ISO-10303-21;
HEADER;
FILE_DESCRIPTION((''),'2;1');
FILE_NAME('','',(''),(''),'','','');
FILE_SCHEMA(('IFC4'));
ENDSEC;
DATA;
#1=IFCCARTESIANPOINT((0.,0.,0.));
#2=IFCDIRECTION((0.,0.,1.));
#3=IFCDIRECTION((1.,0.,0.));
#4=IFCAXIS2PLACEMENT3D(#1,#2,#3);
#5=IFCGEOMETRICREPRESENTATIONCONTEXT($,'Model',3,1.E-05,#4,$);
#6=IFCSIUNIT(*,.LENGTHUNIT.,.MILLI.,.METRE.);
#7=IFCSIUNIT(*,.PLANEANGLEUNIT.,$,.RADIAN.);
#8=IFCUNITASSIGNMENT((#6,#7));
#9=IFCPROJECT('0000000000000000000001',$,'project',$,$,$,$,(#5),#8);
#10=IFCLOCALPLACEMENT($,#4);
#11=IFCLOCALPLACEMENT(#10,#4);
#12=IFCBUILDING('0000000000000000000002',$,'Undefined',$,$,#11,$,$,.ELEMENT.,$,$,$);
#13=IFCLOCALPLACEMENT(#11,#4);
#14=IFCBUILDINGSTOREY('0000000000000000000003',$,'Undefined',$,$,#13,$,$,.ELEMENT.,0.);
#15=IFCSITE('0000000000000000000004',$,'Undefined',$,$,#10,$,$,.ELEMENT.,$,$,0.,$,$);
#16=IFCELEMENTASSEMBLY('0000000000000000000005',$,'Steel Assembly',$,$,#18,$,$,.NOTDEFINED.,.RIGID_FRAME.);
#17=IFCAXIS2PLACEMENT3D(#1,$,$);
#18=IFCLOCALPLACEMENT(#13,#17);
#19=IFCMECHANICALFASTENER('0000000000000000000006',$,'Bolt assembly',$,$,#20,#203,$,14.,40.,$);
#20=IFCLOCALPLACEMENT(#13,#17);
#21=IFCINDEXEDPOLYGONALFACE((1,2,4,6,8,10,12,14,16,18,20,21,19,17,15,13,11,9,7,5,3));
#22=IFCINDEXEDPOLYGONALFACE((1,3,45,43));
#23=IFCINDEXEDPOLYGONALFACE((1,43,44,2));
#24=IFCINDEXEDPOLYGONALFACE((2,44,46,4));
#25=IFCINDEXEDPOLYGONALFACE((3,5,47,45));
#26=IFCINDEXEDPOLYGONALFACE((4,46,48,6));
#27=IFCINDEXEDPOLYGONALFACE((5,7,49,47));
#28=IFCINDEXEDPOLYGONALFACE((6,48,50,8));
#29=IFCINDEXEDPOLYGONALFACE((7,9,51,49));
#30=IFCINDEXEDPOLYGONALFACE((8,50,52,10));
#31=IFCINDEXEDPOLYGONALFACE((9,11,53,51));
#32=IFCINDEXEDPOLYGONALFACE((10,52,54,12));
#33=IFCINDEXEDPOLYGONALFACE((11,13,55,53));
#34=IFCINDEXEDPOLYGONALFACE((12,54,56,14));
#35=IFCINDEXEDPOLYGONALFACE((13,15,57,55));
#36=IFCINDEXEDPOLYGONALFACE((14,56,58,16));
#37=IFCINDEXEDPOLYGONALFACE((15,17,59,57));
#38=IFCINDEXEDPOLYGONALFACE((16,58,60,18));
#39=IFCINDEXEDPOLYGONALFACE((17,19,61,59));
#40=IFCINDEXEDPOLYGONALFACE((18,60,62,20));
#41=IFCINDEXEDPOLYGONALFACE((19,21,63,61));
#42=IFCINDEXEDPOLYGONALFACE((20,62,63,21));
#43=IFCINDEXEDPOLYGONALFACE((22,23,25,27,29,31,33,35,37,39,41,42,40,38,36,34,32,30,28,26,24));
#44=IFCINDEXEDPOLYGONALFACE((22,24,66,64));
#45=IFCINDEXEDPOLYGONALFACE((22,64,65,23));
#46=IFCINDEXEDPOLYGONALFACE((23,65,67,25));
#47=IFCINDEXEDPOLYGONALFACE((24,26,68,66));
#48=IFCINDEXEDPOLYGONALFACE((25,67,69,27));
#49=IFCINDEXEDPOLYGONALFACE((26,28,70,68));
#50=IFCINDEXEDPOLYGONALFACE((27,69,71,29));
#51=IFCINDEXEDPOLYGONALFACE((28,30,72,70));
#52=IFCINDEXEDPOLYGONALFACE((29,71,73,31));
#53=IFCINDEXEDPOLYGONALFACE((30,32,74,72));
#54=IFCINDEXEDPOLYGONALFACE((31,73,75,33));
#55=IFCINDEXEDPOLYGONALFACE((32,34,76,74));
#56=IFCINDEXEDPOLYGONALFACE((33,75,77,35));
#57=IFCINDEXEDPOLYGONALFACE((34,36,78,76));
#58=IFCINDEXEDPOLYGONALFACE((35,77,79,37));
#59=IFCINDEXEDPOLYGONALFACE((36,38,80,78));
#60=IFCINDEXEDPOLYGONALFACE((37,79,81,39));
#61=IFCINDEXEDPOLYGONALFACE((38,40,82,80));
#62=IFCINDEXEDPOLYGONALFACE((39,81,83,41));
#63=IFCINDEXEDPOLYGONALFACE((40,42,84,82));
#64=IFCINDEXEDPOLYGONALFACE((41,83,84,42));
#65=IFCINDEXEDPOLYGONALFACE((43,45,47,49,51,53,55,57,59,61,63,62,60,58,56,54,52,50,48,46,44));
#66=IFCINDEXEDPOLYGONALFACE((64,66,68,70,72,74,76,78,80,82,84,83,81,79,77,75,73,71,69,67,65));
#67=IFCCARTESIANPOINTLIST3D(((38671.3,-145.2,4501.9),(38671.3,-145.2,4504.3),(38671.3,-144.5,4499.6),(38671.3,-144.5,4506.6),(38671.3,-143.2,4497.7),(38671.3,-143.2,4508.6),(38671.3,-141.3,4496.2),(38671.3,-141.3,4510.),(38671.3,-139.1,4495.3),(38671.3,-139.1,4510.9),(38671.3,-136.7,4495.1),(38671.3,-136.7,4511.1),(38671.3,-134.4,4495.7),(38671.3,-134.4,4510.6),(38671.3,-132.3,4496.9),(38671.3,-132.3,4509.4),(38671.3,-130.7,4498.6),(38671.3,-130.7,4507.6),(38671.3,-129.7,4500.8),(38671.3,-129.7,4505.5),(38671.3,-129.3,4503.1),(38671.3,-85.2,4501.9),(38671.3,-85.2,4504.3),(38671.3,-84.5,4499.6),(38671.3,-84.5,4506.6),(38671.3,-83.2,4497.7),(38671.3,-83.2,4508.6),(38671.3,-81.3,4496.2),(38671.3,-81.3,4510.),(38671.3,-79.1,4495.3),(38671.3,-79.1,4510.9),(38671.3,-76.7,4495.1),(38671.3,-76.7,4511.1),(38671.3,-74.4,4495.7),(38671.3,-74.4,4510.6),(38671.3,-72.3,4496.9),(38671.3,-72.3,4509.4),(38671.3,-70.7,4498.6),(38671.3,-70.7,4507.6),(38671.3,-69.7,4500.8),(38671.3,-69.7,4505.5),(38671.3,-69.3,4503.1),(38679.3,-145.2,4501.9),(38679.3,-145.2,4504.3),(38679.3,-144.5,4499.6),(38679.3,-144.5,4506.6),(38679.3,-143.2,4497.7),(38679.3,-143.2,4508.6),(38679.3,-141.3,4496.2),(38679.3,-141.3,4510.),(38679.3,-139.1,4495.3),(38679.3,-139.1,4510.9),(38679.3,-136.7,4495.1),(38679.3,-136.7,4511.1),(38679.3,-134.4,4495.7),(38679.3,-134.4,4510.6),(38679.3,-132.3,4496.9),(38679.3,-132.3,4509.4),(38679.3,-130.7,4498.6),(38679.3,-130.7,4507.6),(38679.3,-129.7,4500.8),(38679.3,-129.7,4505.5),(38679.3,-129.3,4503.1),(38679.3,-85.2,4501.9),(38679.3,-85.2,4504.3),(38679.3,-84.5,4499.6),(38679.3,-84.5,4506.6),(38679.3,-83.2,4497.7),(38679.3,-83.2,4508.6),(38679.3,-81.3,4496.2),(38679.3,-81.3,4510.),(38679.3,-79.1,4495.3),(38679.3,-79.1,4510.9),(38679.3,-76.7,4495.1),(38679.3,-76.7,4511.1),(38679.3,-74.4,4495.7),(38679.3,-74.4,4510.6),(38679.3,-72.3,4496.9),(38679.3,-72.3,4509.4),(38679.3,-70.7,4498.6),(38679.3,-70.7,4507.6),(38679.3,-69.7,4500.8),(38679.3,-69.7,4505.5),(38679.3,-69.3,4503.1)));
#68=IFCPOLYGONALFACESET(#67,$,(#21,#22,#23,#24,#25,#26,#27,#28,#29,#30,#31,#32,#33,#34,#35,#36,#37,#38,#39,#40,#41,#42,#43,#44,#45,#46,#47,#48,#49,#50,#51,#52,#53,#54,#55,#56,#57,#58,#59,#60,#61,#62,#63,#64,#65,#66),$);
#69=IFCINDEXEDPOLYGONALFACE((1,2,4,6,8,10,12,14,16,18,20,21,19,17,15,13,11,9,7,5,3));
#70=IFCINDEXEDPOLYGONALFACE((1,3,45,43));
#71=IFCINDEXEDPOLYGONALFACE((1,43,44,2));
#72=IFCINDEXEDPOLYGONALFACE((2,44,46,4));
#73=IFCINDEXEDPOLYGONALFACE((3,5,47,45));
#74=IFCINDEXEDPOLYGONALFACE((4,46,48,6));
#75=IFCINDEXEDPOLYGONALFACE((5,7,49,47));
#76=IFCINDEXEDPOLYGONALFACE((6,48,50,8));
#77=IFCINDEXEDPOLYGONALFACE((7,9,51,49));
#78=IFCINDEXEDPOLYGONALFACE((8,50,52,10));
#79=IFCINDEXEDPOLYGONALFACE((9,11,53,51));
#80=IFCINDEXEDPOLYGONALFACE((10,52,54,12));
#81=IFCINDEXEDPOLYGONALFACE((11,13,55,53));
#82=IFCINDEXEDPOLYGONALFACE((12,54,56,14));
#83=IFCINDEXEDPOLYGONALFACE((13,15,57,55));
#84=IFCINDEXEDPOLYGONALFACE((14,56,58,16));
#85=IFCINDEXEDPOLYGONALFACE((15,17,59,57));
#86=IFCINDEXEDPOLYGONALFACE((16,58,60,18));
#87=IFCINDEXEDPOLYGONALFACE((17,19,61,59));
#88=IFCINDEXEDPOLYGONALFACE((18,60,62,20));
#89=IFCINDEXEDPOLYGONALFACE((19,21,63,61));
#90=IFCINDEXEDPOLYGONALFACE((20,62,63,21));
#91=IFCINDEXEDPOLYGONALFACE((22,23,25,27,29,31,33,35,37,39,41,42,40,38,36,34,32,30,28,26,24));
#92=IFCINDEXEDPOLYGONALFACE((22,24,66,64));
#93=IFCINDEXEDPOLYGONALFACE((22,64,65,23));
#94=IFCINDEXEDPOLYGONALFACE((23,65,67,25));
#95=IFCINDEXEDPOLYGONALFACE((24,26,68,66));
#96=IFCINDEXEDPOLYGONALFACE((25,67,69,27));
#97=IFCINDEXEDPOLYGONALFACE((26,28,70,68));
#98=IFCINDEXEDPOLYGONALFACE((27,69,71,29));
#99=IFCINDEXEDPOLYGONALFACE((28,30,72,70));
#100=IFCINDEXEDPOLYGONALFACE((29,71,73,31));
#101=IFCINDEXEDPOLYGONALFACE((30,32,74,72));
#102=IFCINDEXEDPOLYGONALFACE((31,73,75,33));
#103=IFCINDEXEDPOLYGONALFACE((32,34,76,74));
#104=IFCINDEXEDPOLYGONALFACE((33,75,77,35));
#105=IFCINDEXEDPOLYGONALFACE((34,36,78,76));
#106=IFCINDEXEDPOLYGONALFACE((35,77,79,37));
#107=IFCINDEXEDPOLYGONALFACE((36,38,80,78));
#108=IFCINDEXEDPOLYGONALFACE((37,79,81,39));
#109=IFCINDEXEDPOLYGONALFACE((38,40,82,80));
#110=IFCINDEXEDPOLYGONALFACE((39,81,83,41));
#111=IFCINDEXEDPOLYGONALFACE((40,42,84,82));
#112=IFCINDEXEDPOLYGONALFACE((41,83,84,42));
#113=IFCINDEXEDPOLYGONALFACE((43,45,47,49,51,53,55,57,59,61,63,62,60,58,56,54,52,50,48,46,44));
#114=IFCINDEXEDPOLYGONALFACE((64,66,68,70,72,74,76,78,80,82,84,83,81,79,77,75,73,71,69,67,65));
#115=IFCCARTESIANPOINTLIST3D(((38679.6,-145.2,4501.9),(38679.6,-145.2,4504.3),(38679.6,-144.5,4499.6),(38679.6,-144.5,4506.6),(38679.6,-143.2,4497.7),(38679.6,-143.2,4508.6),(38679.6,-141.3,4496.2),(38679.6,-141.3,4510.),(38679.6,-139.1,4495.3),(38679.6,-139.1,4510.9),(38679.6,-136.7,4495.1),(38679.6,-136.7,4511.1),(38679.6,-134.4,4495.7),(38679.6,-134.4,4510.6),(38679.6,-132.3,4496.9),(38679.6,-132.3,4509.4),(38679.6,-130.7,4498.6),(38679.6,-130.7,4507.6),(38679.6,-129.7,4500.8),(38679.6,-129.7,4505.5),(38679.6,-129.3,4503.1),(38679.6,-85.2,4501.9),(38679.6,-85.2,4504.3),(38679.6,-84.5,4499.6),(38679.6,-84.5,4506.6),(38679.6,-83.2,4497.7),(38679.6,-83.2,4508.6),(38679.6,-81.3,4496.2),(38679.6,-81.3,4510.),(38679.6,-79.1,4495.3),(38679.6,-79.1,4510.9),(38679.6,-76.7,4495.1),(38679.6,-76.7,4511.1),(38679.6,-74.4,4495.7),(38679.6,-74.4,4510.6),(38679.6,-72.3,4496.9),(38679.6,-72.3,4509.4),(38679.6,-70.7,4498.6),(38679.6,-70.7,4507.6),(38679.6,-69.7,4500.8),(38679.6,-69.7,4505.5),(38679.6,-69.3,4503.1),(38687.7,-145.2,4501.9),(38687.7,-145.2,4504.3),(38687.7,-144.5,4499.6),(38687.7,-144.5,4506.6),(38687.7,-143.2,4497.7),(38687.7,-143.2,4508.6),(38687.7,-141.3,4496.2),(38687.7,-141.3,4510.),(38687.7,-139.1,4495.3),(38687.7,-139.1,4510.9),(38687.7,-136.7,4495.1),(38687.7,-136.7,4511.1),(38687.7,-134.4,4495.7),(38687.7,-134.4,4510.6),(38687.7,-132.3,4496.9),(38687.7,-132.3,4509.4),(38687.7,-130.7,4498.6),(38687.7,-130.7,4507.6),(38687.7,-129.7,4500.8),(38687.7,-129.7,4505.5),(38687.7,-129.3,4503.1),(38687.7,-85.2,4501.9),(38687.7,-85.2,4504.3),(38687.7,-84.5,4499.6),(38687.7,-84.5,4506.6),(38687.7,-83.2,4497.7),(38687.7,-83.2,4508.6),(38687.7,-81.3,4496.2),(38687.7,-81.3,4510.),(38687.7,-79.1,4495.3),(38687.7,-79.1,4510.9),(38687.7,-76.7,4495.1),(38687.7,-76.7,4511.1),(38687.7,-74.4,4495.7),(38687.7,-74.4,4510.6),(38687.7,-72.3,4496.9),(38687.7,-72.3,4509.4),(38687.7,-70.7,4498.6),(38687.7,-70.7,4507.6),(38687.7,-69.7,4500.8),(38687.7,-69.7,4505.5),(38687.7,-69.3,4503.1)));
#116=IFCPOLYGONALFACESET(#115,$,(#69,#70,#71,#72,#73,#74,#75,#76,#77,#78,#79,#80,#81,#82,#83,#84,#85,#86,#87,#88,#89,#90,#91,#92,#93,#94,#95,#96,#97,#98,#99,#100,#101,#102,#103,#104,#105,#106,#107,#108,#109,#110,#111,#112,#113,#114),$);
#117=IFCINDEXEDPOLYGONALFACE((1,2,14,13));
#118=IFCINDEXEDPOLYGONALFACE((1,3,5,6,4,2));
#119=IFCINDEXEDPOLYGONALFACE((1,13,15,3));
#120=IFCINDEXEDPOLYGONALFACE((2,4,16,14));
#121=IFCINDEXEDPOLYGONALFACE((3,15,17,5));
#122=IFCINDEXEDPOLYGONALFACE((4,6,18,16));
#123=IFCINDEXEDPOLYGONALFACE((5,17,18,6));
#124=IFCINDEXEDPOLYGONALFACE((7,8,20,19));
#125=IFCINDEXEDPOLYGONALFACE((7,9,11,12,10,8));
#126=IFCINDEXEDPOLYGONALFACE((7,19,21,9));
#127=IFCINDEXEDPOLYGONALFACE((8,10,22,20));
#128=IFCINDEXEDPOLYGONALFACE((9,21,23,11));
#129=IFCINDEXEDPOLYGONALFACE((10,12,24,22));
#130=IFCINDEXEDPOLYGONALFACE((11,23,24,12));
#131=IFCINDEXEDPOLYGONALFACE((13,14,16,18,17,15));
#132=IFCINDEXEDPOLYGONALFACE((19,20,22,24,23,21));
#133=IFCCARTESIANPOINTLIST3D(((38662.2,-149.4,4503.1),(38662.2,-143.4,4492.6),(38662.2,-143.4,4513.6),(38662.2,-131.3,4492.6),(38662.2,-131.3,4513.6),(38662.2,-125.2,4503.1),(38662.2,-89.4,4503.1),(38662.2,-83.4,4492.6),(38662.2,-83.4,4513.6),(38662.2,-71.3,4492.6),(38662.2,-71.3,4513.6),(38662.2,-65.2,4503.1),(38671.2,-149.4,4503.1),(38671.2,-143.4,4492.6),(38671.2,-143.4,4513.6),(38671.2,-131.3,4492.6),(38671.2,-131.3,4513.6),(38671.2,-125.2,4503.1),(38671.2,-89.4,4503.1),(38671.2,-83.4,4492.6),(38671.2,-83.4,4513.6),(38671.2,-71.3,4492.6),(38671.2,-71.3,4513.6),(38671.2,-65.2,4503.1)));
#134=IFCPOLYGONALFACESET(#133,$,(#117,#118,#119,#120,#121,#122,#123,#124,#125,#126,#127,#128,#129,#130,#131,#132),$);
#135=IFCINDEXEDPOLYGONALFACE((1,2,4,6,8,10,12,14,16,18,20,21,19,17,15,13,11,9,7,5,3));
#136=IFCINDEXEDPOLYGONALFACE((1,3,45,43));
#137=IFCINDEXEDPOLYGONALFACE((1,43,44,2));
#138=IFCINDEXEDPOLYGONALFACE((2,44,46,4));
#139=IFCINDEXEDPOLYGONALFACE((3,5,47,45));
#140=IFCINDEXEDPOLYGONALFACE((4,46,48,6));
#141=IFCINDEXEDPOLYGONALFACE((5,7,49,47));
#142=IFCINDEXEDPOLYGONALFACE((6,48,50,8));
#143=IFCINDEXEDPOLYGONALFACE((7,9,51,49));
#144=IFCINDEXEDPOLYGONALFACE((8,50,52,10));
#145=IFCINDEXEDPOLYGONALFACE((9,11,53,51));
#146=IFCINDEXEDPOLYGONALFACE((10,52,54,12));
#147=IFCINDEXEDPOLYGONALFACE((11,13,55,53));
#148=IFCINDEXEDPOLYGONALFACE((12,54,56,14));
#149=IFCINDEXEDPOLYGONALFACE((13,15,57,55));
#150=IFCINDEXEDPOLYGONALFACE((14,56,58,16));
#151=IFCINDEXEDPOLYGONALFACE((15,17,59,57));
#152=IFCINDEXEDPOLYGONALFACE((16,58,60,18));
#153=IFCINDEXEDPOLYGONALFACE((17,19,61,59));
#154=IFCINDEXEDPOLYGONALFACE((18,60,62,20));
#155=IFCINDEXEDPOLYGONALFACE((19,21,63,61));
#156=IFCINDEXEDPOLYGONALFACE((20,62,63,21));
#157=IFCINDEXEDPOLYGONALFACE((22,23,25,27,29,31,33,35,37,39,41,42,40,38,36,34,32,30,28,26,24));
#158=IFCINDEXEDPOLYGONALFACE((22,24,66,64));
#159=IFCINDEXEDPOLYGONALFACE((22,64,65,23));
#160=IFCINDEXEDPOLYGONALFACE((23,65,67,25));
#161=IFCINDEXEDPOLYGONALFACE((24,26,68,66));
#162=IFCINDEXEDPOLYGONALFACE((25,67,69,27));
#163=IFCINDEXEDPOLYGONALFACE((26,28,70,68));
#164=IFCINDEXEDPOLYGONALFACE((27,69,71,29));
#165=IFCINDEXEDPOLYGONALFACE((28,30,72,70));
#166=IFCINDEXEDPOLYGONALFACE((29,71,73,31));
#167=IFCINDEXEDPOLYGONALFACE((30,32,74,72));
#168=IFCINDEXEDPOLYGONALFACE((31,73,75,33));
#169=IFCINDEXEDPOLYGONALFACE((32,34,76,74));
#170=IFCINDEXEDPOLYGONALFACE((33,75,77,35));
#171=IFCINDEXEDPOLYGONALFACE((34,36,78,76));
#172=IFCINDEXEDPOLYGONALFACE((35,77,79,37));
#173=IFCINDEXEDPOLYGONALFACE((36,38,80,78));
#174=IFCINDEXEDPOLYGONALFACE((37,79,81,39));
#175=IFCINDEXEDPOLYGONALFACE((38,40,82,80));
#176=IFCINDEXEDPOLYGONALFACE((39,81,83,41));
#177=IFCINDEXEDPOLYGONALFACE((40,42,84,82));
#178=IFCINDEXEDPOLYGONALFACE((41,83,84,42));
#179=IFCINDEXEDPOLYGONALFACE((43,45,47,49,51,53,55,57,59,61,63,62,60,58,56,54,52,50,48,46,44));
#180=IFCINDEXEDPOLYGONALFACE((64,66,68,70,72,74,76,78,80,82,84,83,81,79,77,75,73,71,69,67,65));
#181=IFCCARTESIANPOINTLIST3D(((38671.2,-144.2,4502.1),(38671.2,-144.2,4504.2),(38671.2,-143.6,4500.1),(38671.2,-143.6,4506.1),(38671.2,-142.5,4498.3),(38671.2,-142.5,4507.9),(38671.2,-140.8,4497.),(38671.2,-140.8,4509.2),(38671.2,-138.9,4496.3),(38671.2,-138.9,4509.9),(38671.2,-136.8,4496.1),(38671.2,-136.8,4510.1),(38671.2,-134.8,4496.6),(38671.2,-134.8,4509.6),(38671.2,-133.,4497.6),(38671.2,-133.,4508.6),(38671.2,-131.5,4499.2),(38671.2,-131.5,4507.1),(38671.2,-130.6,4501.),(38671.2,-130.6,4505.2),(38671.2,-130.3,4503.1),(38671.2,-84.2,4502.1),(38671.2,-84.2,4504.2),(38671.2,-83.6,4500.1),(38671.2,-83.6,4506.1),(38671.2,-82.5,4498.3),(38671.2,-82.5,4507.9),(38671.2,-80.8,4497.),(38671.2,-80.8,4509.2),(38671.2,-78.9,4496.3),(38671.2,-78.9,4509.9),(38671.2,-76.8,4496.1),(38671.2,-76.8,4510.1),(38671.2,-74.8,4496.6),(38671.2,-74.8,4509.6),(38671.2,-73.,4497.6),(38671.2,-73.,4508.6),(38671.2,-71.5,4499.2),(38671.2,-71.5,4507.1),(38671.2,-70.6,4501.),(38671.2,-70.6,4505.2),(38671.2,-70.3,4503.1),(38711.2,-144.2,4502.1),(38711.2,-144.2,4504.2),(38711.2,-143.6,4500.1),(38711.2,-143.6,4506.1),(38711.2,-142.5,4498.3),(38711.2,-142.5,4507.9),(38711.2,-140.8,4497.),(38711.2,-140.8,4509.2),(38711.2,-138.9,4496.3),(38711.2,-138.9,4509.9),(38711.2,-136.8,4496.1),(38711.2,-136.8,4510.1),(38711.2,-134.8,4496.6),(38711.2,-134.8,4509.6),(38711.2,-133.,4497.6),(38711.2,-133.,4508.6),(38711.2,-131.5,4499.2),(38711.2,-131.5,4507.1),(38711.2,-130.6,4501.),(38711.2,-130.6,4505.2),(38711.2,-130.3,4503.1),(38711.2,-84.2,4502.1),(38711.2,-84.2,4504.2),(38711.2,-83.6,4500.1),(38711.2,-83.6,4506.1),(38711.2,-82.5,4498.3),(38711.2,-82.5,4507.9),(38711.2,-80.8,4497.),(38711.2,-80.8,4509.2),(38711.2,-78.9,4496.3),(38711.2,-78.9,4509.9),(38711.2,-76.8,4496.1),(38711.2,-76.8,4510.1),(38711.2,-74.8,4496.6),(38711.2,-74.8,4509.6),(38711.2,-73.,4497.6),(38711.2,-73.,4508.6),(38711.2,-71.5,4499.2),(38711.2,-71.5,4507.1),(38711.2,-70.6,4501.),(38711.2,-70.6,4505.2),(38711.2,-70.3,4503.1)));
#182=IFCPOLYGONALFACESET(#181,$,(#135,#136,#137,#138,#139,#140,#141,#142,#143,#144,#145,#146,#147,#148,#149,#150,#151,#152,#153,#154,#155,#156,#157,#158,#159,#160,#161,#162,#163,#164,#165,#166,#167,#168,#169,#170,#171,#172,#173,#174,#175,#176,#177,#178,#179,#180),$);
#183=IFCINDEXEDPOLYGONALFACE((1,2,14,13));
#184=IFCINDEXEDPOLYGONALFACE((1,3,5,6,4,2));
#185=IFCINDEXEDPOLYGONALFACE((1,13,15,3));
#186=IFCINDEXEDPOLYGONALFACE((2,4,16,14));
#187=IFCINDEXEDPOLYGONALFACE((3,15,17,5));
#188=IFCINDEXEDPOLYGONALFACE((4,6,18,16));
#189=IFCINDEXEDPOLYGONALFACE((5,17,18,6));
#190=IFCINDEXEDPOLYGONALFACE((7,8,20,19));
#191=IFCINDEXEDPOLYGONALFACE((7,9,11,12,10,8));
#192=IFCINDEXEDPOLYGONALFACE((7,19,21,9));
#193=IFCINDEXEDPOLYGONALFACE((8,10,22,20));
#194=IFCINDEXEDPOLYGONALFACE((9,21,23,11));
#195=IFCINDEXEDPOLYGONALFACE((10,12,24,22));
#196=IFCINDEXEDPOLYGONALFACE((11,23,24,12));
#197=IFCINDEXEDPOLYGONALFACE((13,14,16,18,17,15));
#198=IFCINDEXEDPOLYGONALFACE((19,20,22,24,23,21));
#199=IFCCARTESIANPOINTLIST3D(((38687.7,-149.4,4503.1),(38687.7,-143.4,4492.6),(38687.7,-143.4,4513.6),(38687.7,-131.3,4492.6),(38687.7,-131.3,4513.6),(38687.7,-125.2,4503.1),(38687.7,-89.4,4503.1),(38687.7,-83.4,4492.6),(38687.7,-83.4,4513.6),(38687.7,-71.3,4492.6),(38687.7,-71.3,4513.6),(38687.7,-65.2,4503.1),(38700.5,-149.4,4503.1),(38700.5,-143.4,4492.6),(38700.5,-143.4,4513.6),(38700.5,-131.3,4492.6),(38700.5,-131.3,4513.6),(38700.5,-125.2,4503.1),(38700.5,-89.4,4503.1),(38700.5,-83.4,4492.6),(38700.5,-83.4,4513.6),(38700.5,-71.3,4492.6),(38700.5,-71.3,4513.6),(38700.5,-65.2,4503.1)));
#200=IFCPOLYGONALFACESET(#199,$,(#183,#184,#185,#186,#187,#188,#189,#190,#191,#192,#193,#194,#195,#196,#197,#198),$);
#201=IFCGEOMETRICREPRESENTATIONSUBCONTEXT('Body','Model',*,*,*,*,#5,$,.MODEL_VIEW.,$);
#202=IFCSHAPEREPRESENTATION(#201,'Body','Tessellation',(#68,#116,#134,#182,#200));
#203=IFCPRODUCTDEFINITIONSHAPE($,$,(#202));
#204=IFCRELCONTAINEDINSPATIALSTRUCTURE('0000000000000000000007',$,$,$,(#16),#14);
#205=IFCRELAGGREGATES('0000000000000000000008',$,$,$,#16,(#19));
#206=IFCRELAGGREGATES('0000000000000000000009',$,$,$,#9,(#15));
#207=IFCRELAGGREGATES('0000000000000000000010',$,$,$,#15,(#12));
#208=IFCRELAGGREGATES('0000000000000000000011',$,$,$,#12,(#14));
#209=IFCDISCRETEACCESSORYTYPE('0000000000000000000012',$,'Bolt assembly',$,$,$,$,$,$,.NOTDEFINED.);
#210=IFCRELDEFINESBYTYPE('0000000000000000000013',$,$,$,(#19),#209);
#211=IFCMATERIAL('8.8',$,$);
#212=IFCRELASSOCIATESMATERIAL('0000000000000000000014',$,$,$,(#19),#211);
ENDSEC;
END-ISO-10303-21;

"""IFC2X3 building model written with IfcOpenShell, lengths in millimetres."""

from ifc_helpers import new_model, si_unit, frame, origin_with_axes, origin_2d_with_axis, place, context, subcontext, project, spatial, polyline, circle, outline, extrude, source, transform, mapped, material, type_object, element, aggregate, save


model = new_model("IFC2X3")

# Units and contexts
model_context = context("Model", 3, precision=1e-05, world=origin_with_axes())
body_context = subcontext(model_context, "Body", "Model", "MODEL_VIEW")
ifc_project = project(units=[si_unit("LENGTHUNIT", "METRE", prefix="MILLI"), si_unit("PLANEANGLEUNIT", "RADIAN")], contexts=[model_context])

# Site, building, storey
site_placement = place(None, origin_with_axes())
site = spatial("IfcSite", under=ifc_project, at=site_placement, Name="Undefined", CompositionType="ELEMENT", RefElevation=0.0)
building_placement = place(site_placement, origin_with_axes())
building = spatial("IfcBuilding", under=site, at=building_placement, Name="Undefined", CompositionType="ELEMENT")
storey_placement = place(building_placement, origin_with_axes())
storey = spatial("IfcBuildingStorey", under=building, at=storey_placement, Name="Undefined", CompositionType="ELEMENT", Elevation=0.0)

# Element assembly
assembly_1_placement = place(storey_placement, origin_with_axes())
assembly_1 = element("IfcElementAssembly", 1, at=assembly_1_placement, inside=storey, Name="Steel Assembly", AssemblyPlace="NOTDEFINED", PredefinedType="RIGID_FRAME")

# Shared definitions
discrete_accessory_type_1 = type_object("IfcDiscreteAccessoryType", Name="Bolt assembly")

# Shared definitions
ifc_material_1 = material(Name="8.8")

# Mechanical fastener
shared_shape_1 = source(origin_with_axes(), body_context, "Body", "SweptSolid", [
    extrude(circle(Radius=8.0, at=origin_2d_with_axis()), frame((0.0, -16.4, 0.0), z_axis=(0.0, 1.0, 0.0), x_axis=(1.0, 0.0, 0.0)), (0.0, 0.0, 1.0), 8.0),
    extrude(circle(Radius=8.0, at=origin_2d_with_axis()), frame((0.0, -8.1, 0.0), z_axis=(0.0, 1.0, 0.0), x_axis=(1.0, 0.0, 0.0)), (0.0, 0.0, 1.0), 8.1),
    extrude(outline(polyline([(12.1, 0.0), (6.1, 10.5), (-6.1, 10.5), (-12.1, 0.0), (-6.1, -10.5), (6.1, -10.5), (12.1, 0.0)])), frame((0.0, -25.5, 0.0), z_axis=(0.0, 1.0, 0.0), x_axis=(1.0, 0.0, 0.0)), (0.0, 0.0, 1.0), 9.0),
    extrude(circle(Radius=7.0, at=origin_2d_with_axis()), frame((0.0, -16.5, 0.0), z_axis=(0.0, 1.0, 0.0), x_axis=(1.0, 0.0, 0.0)), (0.0, 0.0, 1.0), 40.0),
    extrude(outline(polyline([(12.1, 0.0), (6.1, 10.5), (-6.1, 10.5), (-12.1, 0.0), (-6.1, -10.5), (6.1, -10.5), (12.1, 0.0)])), frame((0.0, 0.0, 0.0), z_axis=(0.0, 1.0, 0.0), x_axis=(1.0, 0.0, 0.0)), (0.0, 0.0, 1.0), 12.8),
])
mechanical_fastener_1_placement = place(assembly_1_placement, frame((38687.7, -137.3, 4505.6), z_axis=(0.0, 0.0, -1.0), x_axis=(0.0, 1.0, 0.0)))
mechanical_fastener_1 = element("IfcMechanicalFastener", 2, at=mechanical_fastener_1_placement, type_object=discrete_accessory_type_1, material=ifc_material_1, Name="Bolt assembly", NominalDiameter=14.0, NominalLength=40.0, context=body_context, shape_type="MappedRepresentation", body=[
    mapped(shared_shape_1, transform((0.0, 0.0, 2.5))),
    mapped(shared_shape_1, transform((60.0, 0.0, 2.5))),
])
aggregate(assembly_1, [mechanical_fastener_1])

save(model, "model.ifc")
